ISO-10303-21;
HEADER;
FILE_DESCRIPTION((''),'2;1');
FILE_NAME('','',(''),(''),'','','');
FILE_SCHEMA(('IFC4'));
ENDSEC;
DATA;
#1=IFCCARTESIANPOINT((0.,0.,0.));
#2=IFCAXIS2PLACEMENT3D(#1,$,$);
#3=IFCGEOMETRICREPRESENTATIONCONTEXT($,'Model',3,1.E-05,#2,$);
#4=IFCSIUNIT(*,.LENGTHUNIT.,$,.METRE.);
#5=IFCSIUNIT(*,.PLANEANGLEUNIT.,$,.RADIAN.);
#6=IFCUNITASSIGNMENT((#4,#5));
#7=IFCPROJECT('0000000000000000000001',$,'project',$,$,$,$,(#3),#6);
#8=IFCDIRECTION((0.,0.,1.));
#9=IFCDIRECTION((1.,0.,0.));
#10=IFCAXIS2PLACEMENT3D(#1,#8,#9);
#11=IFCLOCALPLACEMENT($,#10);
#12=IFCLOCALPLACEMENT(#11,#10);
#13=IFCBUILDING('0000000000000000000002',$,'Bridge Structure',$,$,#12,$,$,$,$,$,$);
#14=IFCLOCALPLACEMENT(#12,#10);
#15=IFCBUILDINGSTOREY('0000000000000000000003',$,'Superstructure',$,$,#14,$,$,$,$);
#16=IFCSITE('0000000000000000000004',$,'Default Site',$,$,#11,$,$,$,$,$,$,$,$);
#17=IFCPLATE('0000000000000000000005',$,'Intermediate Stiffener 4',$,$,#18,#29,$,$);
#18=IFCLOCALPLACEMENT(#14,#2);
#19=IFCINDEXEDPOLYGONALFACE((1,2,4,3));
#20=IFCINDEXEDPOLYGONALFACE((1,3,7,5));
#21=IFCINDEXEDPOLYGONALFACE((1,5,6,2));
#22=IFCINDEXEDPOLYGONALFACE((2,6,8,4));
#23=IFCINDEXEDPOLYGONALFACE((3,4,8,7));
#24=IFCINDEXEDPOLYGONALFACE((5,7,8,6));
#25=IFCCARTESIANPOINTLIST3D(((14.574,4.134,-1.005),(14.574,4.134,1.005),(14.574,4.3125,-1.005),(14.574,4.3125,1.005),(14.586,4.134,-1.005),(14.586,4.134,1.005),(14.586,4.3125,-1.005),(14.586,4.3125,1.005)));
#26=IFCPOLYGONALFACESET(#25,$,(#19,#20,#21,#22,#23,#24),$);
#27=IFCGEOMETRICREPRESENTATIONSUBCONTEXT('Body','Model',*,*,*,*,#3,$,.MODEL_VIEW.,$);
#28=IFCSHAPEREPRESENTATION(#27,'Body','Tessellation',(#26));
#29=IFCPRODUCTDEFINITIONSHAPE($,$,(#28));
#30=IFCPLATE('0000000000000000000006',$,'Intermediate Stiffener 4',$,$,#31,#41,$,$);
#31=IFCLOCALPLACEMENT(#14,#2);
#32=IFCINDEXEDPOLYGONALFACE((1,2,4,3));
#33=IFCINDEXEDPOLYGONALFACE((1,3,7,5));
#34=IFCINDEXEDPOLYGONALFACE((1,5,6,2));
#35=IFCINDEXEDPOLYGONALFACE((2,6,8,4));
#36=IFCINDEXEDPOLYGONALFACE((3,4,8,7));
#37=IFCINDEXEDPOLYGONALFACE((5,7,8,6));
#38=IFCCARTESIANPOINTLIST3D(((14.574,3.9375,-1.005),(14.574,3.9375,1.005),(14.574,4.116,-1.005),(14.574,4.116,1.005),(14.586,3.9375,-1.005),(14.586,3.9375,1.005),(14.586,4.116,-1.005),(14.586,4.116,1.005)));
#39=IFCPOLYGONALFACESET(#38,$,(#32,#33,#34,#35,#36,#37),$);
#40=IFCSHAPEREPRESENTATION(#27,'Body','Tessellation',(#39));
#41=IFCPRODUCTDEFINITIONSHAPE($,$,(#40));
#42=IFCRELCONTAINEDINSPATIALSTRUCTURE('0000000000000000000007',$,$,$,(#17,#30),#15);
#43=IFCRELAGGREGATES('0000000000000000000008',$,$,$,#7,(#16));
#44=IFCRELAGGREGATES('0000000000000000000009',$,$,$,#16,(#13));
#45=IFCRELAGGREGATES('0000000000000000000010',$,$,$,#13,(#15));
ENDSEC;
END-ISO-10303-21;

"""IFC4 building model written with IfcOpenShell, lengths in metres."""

from ifc_helpers import new_model, si_unit, frame, origin, origin_with_axes, origin_2d_with_axis, place, context, subcontext, project, spatial, rectangle, extrude, element, save


model = new_model("IFC4")

# Units and contexts
model_context = context("Model", 3, precision=1e-05, world=origin())
body_context = subcontext(model_context, "Body", "Model", "MODEL_VIEW")
ifc_project = project(units=[si_unit("LENGTHUNIT", "METRE"), si_unit("PLANEANGLEUNIT", "RADIAN")], contexts=[model_context])

# Site, building, storey
site_placement = place(None, origin_with_axes())
site = spatial("IfcSite", under=ifc_project, at=site_placement, Name="Default Site")
building_placement = place(site_placement, origin_with_axes())
building = spatial("IfcBuilding", under=site, at=building_placement, Name="Bridge Structure")
storey_placement = place(building_placement, origin_with_axes())
storey = spatial("IfcBuildingStorey", under=building, at=storey_placement, Name="Superstructure")

# Plates
for number, where, z_axis, x_axis, name in (
    (1, (14.58, 4.2233, -1.005), (0.0, 0.0, 1.0), (1.0, 0.0, 0.0), "Intermediate Stiffener 4"),
    (2, (14.58, 4.0267, -1.005), (0.0, 0.0, 1.0), (1.0, 0.0, 0.0), "Intermediate Stiffener 4"),
):
    element("IfcPlate", number, at=place(storey_placement, frame(where, z_axis=z_axis, x_axis=x_axis)), inside=storey, Name=name, context=body_context, shape_type="SweptSolid", body=[
        extrude(rectangle(XDim=0.012, YDim=0.1785, at=origin_2d_with_axis()), origin_with_axes(), (0.0, 0.0, 1.0), 2.01),
    ])

save(model, "model.ifc")
